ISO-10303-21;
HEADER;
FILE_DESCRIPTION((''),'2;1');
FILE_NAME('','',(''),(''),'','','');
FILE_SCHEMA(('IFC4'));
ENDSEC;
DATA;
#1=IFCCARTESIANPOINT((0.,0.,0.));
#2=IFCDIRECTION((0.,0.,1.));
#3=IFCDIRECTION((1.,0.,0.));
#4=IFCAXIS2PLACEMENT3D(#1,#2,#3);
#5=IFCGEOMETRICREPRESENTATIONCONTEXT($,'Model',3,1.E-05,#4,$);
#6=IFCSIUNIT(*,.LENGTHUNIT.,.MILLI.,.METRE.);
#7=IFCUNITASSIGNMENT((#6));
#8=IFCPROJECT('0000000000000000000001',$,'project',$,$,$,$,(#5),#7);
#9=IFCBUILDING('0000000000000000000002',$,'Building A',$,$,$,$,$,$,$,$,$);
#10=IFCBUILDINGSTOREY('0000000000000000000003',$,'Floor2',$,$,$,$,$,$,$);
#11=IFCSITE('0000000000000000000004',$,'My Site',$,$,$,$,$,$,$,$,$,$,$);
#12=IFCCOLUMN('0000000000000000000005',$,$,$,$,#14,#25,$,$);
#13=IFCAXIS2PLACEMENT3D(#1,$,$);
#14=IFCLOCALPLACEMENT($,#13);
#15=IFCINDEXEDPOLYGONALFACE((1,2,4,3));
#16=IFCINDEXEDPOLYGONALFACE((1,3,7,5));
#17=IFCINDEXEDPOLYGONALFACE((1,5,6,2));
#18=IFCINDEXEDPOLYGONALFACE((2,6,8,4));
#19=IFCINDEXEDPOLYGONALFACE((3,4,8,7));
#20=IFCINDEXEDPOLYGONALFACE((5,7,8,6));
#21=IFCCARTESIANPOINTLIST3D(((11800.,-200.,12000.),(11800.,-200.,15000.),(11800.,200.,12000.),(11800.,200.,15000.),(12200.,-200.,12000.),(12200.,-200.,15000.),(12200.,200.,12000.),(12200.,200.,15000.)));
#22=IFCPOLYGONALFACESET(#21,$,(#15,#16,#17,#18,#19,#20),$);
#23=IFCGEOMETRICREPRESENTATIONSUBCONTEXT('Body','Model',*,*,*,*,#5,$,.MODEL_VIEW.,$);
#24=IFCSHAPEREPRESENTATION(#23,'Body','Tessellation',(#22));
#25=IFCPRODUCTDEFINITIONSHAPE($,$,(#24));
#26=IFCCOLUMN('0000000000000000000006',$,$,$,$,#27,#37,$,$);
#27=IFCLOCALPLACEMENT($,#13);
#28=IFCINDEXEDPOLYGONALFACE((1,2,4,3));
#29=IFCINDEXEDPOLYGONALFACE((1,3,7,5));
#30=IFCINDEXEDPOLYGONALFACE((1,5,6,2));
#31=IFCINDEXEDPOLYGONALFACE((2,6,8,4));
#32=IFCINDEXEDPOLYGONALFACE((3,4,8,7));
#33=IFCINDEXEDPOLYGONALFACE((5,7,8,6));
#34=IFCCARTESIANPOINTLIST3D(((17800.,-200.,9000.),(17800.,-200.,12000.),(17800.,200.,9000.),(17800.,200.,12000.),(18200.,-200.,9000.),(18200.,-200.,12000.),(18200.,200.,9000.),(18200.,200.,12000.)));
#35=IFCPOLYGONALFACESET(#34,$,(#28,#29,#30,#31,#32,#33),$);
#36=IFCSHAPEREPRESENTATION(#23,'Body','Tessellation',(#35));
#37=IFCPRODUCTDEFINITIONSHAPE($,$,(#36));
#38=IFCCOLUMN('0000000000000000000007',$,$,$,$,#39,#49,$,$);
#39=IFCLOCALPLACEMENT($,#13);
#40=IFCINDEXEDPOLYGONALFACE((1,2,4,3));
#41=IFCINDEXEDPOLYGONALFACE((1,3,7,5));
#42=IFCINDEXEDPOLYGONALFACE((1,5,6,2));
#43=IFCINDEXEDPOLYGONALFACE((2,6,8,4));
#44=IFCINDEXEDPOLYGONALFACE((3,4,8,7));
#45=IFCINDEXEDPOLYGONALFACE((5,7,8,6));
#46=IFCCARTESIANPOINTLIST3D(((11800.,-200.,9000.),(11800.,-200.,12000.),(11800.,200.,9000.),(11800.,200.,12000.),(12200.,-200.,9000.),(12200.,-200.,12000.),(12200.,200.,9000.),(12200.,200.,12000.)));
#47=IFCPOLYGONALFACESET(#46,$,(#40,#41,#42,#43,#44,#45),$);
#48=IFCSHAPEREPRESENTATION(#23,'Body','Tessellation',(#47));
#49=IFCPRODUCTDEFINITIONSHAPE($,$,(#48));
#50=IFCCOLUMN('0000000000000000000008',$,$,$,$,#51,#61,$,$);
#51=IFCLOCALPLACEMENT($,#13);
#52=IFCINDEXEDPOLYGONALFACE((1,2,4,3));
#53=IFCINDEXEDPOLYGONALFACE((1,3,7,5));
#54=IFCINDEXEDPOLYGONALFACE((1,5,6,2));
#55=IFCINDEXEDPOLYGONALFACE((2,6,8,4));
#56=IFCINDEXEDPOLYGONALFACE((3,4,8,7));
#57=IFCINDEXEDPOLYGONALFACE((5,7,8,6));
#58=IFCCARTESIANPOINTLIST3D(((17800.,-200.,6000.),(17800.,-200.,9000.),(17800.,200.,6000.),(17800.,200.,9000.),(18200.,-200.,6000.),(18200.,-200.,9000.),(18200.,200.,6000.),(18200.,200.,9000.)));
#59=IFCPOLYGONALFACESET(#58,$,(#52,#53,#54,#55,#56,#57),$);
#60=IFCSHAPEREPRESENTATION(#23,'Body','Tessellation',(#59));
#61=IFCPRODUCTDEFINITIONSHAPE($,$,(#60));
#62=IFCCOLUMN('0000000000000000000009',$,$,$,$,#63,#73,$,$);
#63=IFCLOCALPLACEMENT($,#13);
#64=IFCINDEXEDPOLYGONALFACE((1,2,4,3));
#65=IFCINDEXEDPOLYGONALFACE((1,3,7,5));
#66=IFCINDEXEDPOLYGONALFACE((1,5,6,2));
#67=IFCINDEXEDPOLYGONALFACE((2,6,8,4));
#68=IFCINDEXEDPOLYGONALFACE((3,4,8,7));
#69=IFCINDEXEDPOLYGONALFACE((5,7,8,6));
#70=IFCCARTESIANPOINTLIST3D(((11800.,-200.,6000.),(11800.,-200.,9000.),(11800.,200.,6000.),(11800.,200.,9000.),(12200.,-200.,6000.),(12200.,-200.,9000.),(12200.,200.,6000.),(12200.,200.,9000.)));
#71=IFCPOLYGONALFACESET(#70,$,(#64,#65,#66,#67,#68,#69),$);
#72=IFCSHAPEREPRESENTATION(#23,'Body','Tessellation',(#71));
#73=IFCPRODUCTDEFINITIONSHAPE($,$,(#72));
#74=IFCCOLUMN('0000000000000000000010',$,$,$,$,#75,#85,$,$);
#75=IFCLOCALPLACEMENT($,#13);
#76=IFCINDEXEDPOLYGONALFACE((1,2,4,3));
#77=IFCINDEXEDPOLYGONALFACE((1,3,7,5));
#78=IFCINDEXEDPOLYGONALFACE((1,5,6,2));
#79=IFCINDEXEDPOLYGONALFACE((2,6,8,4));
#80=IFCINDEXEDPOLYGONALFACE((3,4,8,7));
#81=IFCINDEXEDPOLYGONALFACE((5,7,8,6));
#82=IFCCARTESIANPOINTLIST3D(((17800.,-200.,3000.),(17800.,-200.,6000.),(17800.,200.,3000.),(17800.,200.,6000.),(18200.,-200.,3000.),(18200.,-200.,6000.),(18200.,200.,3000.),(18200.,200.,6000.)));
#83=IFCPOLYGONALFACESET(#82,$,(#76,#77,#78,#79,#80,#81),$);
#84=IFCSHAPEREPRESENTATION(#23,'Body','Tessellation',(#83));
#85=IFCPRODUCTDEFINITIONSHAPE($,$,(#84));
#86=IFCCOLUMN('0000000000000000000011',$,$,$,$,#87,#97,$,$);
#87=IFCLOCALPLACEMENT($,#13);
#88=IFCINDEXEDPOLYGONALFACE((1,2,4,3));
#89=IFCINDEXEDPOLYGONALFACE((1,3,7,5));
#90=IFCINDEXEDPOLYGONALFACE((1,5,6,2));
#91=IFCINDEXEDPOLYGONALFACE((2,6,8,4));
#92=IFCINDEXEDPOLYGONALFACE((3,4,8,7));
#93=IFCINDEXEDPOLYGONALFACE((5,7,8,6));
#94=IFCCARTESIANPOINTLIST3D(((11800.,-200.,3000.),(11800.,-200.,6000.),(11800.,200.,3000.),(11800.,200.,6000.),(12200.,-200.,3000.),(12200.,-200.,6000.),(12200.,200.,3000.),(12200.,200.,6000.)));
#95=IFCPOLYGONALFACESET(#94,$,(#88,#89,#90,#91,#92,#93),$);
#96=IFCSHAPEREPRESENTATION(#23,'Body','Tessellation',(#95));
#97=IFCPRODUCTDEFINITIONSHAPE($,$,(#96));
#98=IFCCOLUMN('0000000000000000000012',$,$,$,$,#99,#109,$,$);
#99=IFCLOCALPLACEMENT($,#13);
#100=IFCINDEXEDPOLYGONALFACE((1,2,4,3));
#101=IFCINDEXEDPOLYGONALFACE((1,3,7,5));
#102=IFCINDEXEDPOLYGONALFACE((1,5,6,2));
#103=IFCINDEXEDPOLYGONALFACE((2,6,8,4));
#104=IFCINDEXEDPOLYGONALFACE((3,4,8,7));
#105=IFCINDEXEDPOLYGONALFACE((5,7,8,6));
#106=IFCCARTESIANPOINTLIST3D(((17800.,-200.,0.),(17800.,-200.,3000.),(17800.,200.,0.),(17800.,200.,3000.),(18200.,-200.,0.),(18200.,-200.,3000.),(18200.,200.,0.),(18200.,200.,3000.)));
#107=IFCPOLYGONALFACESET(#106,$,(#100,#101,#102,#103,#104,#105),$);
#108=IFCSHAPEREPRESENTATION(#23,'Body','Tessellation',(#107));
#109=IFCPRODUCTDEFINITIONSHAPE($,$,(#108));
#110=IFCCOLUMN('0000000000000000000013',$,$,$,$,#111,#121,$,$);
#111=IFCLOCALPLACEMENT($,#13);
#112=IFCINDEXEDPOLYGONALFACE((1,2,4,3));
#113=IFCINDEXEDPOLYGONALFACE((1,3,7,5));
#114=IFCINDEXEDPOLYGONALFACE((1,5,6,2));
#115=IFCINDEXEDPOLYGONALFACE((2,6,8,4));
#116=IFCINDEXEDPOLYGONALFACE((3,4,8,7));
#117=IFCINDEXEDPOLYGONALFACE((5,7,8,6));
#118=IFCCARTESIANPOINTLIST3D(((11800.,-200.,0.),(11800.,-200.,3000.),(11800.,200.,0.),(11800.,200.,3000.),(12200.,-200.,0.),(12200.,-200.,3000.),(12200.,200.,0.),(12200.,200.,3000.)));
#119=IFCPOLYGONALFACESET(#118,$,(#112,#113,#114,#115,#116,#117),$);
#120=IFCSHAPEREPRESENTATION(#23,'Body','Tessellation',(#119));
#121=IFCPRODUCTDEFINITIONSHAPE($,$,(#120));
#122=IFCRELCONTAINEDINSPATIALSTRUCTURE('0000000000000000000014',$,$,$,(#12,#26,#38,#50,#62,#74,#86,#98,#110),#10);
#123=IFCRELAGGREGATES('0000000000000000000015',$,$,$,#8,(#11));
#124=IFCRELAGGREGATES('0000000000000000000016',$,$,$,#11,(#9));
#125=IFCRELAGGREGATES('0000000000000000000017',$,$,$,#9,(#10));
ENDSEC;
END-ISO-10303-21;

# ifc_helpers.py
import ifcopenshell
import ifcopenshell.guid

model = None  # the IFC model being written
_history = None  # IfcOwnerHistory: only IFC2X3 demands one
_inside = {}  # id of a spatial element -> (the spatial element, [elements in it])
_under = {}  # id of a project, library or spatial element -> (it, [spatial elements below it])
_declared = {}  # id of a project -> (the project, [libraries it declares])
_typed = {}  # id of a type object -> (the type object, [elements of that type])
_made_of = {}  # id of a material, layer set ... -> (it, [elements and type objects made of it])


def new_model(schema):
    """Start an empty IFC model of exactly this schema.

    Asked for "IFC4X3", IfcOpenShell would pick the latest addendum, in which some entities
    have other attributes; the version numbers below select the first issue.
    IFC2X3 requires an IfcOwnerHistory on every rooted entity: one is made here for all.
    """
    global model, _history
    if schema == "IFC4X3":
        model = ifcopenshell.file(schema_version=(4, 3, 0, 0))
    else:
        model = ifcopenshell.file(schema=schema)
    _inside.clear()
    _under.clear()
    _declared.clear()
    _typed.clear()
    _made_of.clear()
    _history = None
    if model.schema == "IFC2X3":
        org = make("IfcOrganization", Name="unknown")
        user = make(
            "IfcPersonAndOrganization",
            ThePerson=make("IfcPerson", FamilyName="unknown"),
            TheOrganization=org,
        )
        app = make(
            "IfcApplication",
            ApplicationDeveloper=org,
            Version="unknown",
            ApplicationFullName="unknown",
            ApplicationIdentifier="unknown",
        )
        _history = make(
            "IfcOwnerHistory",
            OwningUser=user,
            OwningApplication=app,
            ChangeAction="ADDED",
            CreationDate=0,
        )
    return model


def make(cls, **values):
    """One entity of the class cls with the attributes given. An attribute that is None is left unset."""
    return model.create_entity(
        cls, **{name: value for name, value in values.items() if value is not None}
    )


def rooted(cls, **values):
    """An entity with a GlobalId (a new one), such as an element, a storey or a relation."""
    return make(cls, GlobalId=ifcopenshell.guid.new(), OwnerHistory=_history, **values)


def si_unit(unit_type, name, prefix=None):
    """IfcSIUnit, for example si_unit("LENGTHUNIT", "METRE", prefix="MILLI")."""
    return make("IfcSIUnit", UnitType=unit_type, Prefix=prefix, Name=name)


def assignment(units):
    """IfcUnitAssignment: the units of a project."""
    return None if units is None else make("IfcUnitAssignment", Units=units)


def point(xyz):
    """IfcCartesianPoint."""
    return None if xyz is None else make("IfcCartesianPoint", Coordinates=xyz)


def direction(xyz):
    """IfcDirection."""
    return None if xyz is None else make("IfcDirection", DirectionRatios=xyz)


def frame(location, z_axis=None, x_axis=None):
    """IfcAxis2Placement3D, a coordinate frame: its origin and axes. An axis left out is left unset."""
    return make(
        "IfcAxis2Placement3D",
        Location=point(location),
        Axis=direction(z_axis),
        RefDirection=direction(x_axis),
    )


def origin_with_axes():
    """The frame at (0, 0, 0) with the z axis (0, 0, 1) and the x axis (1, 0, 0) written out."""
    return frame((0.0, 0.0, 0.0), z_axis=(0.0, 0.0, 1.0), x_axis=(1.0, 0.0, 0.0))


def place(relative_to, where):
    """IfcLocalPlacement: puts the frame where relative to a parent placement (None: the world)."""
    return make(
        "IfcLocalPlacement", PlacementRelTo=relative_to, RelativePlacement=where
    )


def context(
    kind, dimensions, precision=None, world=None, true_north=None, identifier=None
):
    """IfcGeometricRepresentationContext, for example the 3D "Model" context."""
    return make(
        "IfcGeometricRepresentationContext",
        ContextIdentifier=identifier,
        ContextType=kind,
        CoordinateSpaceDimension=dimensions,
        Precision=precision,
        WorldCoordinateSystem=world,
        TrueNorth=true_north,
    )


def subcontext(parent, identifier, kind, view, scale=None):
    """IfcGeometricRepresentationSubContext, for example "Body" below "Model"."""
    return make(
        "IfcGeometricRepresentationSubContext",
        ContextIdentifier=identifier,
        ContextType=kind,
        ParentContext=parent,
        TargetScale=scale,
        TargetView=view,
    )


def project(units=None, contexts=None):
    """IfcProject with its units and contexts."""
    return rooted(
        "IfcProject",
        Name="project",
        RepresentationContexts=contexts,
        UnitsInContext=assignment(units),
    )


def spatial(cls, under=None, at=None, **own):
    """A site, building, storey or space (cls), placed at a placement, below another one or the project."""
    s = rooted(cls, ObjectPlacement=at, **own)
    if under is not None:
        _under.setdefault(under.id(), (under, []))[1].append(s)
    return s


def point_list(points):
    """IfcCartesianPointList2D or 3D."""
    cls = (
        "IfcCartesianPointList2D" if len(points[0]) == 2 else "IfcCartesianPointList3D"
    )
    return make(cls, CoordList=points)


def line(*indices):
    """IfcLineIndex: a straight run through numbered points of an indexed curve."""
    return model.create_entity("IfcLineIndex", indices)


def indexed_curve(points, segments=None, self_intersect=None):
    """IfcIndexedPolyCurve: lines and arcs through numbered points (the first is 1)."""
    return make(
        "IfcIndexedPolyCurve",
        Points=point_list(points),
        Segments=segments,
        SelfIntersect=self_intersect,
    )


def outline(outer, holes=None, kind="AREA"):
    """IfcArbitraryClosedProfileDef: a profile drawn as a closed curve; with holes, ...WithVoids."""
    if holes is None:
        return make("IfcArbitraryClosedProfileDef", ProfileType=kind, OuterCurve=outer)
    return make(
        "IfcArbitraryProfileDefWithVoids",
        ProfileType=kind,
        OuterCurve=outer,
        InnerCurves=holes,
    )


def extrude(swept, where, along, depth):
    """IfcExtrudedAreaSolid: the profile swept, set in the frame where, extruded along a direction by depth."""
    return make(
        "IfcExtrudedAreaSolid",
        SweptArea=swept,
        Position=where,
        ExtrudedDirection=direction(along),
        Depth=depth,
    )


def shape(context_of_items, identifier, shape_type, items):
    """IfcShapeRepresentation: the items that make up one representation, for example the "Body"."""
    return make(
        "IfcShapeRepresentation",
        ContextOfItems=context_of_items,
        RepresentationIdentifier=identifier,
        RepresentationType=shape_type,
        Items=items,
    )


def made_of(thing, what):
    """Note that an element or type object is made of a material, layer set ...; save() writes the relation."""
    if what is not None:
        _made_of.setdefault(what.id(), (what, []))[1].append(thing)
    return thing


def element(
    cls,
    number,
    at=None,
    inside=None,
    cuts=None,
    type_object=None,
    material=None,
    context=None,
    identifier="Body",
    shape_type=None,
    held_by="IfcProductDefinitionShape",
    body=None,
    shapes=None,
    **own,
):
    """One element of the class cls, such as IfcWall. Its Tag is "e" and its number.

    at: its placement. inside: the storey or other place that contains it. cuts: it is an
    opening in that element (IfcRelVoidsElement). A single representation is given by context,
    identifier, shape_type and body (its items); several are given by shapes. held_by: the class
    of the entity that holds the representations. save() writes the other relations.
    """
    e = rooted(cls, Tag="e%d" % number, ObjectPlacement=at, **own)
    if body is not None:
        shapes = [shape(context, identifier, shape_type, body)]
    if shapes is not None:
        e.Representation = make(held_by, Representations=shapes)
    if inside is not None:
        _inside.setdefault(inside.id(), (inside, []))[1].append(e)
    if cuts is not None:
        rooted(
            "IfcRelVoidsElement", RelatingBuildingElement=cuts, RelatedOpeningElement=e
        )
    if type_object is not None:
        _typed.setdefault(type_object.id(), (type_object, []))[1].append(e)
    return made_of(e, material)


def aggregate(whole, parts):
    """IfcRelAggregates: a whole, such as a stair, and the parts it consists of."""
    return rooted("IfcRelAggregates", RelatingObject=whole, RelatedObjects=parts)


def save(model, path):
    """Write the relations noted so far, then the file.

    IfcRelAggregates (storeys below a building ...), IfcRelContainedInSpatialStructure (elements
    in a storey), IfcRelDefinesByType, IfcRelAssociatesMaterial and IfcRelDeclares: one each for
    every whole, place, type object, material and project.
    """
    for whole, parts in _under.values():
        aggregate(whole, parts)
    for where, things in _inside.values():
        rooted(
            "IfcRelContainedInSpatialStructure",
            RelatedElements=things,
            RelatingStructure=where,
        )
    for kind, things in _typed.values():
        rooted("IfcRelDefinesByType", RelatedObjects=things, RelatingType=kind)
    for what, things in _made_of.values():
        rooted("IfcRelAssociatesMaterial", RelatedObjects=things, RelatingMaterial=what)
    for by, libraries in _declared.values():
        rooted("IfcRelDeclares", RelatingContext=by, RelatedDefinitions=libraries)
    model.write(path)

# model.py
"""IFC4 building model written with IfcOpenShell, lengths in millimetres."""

from ifc_helpers import new_model, si_unit, frame, origin_with_axes, place, context, subcontext, project, spatial, line, indexed_curve, outline, extrude, element, save


model = new_model("IFC4")

# Units and contexts
model_context = context("Model", 3, precision=1e-05, world=origin_with_axes())
body_context = subcontext(model_context, "Body", "Model", "MODEL_VIEW")
ifc_project = project(units=[si_unit("LENGTHUNIT", "METRE", prefix="MILLI")], contexts=[model_context])

# Site, building, storey
site = spatial("IfcSite", under=ifc_project, Name="My Site")
building = spatial("IfcBuilding", under=site, Name="Building A")
storey = spatial("IfcBuildingStorey", under=building, Name="Floor2")

# Columns
for number, where, z_axis, x_axis in (
    (1, (12000.0, 0.0, 12000.0), (0.0, 0.0, 1.0), (1.0, 0.0, 0.0)),
    (2, (18000.0, 0.0, 9000.0), (0.0, 0.0, 1.0), (1.0, 0.0, 0.0)),
    (3, (12000.0, 0.0, 9000.0), (0.0, 0.0, 1.0), (1.0, 0.0, 0.0)),
    (4, (18000.0, 0.0, 6000.0), (0.0, 0.0, 1.0), (1.0, 0.0, 0.0)),
    (5, (12000.0, 0.0, 6000.0), (0.0, 0.0, 1.0), (1.0, 0.0, 0.0)),
    (6, (18000.0, 0.0, 3000.0), (0.0, 0.0, 1.0), (1.0, 0.0, 0.0)),
    (7, (12000.0, 0.0, 3000.0), (0.0, 0.0, 1.0), (1.0, 0.0, 0.0)),
    (8, (18000.0, 0.0, 0.0), (0.0, 0.0, 1.0), (1.0, 0.0, 0.0)),
    (9, (12000.0, 0.0, 0.0), (0.0, 0.0, 1.0), (1.0, 0.0, 0.0)),
):
    element("IfcColumn", number, at=place(None, frame(where, z_axis=z_axis, x_axis=x_axis)), inside=storey, context=body_context, shape_type="SweptSolid", body=[
        extrude(outline(indexed_curve([(-200.0, -200.0), (200.0, -200.0), (200.0, 200.0), (-200.0, 200.0)], segments=[line(1, 2, 3, 4, 1)])), origin_with_axes(), (0.0, 0.0, 1.0), 3000.0),
    ])

save(model, "model.ifc")
